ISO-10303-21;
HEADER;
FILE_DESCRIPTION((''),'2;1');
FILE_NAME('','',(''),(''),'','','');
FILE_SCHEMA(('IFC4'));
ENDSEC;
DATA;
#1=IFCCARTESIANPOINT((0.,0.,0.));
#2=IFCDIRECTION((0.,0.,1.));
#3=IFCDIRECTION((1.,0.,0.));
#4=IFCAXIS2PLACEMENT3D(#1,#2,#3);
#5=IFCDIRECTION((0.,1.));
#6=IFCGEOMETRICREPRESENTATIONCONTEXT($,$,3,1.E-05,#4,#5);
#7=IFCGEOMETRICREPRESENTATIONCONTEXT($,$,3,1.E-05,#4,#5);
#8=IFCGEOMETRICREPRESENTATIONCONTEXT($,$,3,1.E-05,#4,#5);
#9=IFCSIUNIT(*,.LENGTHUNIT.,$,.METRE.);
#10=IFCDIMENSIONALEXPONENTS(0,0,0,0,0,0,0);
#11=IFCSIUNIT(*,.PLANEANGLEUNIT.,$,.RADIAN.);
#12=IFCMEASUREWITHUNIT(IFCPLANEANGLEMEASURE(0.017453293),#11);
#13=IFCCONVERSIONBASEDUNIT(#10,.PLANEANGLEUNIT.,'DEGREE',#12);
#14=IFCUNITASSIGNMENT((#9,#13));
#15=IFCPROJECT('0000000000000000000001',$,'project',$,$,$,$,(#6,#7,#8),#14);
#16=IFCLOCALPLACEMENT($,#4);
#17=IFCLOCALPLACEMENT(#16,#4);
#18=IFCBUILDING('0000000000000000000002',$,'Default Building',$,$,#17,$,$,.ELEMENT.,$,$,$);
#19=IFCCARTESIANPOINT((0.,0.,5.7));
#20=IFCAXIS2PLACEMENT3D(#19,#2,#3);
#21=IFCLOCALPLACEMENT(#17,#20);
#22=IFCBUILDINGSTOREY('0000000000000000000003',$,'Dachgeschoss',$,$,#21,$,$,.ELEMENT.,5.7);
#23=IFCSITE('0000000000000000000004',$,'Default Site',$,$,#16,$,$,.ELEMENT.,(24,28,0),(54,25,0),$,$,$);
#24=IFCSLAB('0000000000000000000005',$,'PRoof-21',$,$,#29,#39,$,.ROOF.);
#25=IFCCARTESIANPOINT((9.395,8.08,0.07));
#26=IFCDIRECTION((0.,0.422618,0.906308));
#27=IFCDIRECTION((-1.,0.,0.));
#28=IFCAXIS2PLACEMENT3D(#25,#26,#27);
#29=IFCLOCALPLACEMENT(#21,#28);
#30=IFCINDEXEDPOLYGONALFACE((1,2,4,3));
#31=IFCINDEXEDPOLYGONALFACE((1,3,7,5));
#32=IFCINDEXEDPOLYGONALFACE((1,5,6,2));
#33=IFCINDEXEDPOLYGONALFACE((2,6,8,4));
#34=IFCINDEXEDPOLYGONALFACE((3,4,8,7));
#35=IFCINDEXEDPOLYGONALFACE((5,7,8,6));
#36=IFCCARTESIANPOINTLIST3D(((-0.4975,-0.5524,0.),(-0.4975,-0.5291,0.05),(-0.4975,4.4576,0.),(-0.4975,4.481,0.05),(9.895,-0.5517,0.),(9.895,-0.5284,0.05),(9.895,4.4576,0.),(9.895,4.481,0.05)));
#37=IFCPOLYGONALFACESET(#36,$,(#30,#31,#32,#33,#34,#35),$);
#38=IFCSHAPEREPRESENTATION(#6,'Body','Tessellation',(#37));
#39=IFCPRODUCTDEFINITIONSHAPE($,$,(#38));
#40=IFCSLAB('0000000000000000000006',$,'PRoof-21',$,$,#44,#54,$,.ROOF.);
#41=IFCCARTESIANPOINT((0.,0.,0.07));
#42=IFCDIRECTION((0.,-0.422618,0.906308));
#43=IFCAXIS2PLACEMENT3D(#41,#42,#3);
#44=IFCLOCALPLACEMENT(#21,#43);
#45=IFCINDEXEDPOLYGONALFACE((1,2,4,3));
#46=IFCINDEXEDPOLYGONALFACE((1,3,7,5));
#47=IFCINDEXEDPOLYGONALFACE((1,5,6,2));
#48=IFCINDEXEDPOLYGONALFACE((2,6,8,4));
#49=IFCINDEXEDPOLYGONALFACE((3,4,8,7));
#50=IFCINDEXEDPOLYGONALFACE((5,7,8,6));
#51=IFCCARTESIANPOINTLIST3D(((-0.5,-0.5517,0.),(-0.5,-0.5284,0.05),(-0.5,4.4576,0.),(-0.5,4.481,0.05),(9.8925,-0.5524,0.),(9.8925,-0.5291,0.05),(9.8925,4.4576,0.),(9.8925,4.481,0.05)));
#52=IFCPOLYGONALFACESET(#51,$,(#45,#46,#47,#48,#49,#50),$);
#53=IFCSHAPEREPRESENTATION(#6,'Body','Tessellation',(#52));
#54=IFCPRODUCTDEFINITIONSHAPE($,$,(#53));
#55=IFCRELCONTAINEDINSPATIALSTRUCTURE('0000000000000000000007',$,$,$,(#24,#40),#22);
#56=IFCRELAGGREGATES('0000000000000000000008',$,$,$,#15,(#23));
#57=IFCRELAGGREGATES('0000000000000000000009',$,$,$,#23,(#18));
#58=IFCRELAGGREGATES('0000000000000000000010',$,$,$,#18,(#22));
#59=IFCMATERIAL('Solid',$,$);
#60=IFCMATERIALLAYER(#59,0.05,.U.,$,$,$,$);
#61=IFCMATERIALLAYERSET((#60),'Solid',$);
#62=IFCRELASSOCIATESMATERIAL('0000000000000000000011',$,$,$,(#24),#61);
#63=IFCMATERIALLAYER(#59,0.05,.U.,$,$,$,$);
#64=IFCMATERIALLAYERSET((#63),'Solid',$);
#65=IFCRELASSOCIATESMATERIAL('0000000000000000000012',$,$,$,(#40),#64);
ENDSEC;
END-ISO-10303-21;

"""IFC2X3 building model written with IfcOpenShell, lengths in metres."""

from ifc_helpers import new_model, entity, si_unit, converted_unit, direction, frame, origin_with_axes, place, context, project, spatial, polyline, outline, extrude, material, layer, layer_set, layer_usage, element, save


model = new_model("IFC2X3")

# Units and contexts
context_of_model_1 = context(None, 3, precision=1e-05, world=origin_with_axes(), true_north=direction((0.0, 1.0)))
context_of_model_2 = context(None, 3, precision=1e-05, world=origin_with_axes(), true_north=direction((0.0, 1.0)))
context_of_model_3 = context(None, 3, precision=1e-05, world=origin_with_axes(), true_north=direction((0.0, 1.0)))
ifc_project = project(units=[si_unit("LENGTHUNIT", "METRE"), converted_unit("PLANEANGLEUNIT", "DEGREE", entity("IfcPlaneAngleMeasure", 0.017453293), si_unit("PLANEANGLEUNIT", "RADIAN"), dimensions=[0, 0, 0, 0, 0, 0, 0])], contexts=[context_of_model_1, context_of_model_2, context_of_model_3])

# Site, building, storey
site_placement = place(None, origin_with_axes())
site = spatial("IfcSite", under=ifc_project, at=site_placement, Name="Default Site", CompositionType="ELEMENT", RefLatitude=(24, 28, 0), RefLongitude=(54, 25, 0))
building_placement = place(site_placement, origin_with_axes())
building = spatial("IfcBuilding", under=site, at=building_placement, Name="Default Building", CompositionType="ELEMENT")
storey_placement = place(building_placement, frame((0.0, 0.0, 5.7), z_axis=(0.0, 0.0, 1.0), x_axis=(1.0, 0.0, 0.0)))
storey = spatial("IfcBuildingStorey", under=building, at=storey_placement, Name="Dachgeschoss", CompositionType="ELEMENT", Elevation=5.7)

# Slabs
ifc_material_1 = material(Name="Solid")
ifc_layer_1 = layer(ifc_material_1, 0.05, ventilated="UNKNOWN")
ifc_layer_set_1 = layer_set([ifc_layer_1], Name="Solid")
ifc_layer_usage_1 = layer_usage(ifc_layer_set_1, "AXIS3", "NEGATIVE", 0.05)
slab_1_placement = place(storey_placement, frame((9.395, 8.08, 0.07), z_axis=(0.0, 0.422618, 0.906308), x_axis=(-1.0, 0.0, 0.0)))
element("IfcSlab", 1, at=slab_1_placement, inside=storey, material=ifc_layer_usage_1, Name="PRoof-21", PredefinedType="ROOF", context=context_of_model_1, shape_type="SweptSolid", body=[
    extrude(outline(polyline([(9.895, 4.4576), (9.895, -0.5517), (-0.4975, -0.5524), (-0.4975, 4.4576), (9.895, 4.4576)])), origin_with_axes(), (0.0, 0.422618, 0.906308), 0.0552),
])
ifc_layer_2 = layer(ifc_material_1, 0.05, ventilated="UNKNOWN")
ifc_layer_set_2 = layer_set([ifc_layer_2], Name="Solid")
ifc_layer_usage_2 = layer_usage(ifc_layer_set_2, "AXIS3", "NEGATIVE", 0.05)
slab_2_placement = place(storey_placement, frame((0.0, 0.0, 0.07), z_axis=(0.0, -0.422618, 0.906308), x_axis=(1.0, 0.0, 0.0)))
element("IfcSlab", 2, at=slab_2_placement, inside=storey, material=ifc_layer_usage_2, Name="PRoof-21", PredefinedType="ROOF", context=context_of_model_1, shape_type="SweptSolid", body=[
    extrude(outline(polyline([(-0.5, 4.4576), (-0.5, -0.5517), (9.8925, -0.5524), (9.8925, 4.4576), (-0.5, 4.4576)])), origin_with_axes(), (0.0, 0.422618, 0.906308), 0.0552),
])

save(model, "model.ifc")
